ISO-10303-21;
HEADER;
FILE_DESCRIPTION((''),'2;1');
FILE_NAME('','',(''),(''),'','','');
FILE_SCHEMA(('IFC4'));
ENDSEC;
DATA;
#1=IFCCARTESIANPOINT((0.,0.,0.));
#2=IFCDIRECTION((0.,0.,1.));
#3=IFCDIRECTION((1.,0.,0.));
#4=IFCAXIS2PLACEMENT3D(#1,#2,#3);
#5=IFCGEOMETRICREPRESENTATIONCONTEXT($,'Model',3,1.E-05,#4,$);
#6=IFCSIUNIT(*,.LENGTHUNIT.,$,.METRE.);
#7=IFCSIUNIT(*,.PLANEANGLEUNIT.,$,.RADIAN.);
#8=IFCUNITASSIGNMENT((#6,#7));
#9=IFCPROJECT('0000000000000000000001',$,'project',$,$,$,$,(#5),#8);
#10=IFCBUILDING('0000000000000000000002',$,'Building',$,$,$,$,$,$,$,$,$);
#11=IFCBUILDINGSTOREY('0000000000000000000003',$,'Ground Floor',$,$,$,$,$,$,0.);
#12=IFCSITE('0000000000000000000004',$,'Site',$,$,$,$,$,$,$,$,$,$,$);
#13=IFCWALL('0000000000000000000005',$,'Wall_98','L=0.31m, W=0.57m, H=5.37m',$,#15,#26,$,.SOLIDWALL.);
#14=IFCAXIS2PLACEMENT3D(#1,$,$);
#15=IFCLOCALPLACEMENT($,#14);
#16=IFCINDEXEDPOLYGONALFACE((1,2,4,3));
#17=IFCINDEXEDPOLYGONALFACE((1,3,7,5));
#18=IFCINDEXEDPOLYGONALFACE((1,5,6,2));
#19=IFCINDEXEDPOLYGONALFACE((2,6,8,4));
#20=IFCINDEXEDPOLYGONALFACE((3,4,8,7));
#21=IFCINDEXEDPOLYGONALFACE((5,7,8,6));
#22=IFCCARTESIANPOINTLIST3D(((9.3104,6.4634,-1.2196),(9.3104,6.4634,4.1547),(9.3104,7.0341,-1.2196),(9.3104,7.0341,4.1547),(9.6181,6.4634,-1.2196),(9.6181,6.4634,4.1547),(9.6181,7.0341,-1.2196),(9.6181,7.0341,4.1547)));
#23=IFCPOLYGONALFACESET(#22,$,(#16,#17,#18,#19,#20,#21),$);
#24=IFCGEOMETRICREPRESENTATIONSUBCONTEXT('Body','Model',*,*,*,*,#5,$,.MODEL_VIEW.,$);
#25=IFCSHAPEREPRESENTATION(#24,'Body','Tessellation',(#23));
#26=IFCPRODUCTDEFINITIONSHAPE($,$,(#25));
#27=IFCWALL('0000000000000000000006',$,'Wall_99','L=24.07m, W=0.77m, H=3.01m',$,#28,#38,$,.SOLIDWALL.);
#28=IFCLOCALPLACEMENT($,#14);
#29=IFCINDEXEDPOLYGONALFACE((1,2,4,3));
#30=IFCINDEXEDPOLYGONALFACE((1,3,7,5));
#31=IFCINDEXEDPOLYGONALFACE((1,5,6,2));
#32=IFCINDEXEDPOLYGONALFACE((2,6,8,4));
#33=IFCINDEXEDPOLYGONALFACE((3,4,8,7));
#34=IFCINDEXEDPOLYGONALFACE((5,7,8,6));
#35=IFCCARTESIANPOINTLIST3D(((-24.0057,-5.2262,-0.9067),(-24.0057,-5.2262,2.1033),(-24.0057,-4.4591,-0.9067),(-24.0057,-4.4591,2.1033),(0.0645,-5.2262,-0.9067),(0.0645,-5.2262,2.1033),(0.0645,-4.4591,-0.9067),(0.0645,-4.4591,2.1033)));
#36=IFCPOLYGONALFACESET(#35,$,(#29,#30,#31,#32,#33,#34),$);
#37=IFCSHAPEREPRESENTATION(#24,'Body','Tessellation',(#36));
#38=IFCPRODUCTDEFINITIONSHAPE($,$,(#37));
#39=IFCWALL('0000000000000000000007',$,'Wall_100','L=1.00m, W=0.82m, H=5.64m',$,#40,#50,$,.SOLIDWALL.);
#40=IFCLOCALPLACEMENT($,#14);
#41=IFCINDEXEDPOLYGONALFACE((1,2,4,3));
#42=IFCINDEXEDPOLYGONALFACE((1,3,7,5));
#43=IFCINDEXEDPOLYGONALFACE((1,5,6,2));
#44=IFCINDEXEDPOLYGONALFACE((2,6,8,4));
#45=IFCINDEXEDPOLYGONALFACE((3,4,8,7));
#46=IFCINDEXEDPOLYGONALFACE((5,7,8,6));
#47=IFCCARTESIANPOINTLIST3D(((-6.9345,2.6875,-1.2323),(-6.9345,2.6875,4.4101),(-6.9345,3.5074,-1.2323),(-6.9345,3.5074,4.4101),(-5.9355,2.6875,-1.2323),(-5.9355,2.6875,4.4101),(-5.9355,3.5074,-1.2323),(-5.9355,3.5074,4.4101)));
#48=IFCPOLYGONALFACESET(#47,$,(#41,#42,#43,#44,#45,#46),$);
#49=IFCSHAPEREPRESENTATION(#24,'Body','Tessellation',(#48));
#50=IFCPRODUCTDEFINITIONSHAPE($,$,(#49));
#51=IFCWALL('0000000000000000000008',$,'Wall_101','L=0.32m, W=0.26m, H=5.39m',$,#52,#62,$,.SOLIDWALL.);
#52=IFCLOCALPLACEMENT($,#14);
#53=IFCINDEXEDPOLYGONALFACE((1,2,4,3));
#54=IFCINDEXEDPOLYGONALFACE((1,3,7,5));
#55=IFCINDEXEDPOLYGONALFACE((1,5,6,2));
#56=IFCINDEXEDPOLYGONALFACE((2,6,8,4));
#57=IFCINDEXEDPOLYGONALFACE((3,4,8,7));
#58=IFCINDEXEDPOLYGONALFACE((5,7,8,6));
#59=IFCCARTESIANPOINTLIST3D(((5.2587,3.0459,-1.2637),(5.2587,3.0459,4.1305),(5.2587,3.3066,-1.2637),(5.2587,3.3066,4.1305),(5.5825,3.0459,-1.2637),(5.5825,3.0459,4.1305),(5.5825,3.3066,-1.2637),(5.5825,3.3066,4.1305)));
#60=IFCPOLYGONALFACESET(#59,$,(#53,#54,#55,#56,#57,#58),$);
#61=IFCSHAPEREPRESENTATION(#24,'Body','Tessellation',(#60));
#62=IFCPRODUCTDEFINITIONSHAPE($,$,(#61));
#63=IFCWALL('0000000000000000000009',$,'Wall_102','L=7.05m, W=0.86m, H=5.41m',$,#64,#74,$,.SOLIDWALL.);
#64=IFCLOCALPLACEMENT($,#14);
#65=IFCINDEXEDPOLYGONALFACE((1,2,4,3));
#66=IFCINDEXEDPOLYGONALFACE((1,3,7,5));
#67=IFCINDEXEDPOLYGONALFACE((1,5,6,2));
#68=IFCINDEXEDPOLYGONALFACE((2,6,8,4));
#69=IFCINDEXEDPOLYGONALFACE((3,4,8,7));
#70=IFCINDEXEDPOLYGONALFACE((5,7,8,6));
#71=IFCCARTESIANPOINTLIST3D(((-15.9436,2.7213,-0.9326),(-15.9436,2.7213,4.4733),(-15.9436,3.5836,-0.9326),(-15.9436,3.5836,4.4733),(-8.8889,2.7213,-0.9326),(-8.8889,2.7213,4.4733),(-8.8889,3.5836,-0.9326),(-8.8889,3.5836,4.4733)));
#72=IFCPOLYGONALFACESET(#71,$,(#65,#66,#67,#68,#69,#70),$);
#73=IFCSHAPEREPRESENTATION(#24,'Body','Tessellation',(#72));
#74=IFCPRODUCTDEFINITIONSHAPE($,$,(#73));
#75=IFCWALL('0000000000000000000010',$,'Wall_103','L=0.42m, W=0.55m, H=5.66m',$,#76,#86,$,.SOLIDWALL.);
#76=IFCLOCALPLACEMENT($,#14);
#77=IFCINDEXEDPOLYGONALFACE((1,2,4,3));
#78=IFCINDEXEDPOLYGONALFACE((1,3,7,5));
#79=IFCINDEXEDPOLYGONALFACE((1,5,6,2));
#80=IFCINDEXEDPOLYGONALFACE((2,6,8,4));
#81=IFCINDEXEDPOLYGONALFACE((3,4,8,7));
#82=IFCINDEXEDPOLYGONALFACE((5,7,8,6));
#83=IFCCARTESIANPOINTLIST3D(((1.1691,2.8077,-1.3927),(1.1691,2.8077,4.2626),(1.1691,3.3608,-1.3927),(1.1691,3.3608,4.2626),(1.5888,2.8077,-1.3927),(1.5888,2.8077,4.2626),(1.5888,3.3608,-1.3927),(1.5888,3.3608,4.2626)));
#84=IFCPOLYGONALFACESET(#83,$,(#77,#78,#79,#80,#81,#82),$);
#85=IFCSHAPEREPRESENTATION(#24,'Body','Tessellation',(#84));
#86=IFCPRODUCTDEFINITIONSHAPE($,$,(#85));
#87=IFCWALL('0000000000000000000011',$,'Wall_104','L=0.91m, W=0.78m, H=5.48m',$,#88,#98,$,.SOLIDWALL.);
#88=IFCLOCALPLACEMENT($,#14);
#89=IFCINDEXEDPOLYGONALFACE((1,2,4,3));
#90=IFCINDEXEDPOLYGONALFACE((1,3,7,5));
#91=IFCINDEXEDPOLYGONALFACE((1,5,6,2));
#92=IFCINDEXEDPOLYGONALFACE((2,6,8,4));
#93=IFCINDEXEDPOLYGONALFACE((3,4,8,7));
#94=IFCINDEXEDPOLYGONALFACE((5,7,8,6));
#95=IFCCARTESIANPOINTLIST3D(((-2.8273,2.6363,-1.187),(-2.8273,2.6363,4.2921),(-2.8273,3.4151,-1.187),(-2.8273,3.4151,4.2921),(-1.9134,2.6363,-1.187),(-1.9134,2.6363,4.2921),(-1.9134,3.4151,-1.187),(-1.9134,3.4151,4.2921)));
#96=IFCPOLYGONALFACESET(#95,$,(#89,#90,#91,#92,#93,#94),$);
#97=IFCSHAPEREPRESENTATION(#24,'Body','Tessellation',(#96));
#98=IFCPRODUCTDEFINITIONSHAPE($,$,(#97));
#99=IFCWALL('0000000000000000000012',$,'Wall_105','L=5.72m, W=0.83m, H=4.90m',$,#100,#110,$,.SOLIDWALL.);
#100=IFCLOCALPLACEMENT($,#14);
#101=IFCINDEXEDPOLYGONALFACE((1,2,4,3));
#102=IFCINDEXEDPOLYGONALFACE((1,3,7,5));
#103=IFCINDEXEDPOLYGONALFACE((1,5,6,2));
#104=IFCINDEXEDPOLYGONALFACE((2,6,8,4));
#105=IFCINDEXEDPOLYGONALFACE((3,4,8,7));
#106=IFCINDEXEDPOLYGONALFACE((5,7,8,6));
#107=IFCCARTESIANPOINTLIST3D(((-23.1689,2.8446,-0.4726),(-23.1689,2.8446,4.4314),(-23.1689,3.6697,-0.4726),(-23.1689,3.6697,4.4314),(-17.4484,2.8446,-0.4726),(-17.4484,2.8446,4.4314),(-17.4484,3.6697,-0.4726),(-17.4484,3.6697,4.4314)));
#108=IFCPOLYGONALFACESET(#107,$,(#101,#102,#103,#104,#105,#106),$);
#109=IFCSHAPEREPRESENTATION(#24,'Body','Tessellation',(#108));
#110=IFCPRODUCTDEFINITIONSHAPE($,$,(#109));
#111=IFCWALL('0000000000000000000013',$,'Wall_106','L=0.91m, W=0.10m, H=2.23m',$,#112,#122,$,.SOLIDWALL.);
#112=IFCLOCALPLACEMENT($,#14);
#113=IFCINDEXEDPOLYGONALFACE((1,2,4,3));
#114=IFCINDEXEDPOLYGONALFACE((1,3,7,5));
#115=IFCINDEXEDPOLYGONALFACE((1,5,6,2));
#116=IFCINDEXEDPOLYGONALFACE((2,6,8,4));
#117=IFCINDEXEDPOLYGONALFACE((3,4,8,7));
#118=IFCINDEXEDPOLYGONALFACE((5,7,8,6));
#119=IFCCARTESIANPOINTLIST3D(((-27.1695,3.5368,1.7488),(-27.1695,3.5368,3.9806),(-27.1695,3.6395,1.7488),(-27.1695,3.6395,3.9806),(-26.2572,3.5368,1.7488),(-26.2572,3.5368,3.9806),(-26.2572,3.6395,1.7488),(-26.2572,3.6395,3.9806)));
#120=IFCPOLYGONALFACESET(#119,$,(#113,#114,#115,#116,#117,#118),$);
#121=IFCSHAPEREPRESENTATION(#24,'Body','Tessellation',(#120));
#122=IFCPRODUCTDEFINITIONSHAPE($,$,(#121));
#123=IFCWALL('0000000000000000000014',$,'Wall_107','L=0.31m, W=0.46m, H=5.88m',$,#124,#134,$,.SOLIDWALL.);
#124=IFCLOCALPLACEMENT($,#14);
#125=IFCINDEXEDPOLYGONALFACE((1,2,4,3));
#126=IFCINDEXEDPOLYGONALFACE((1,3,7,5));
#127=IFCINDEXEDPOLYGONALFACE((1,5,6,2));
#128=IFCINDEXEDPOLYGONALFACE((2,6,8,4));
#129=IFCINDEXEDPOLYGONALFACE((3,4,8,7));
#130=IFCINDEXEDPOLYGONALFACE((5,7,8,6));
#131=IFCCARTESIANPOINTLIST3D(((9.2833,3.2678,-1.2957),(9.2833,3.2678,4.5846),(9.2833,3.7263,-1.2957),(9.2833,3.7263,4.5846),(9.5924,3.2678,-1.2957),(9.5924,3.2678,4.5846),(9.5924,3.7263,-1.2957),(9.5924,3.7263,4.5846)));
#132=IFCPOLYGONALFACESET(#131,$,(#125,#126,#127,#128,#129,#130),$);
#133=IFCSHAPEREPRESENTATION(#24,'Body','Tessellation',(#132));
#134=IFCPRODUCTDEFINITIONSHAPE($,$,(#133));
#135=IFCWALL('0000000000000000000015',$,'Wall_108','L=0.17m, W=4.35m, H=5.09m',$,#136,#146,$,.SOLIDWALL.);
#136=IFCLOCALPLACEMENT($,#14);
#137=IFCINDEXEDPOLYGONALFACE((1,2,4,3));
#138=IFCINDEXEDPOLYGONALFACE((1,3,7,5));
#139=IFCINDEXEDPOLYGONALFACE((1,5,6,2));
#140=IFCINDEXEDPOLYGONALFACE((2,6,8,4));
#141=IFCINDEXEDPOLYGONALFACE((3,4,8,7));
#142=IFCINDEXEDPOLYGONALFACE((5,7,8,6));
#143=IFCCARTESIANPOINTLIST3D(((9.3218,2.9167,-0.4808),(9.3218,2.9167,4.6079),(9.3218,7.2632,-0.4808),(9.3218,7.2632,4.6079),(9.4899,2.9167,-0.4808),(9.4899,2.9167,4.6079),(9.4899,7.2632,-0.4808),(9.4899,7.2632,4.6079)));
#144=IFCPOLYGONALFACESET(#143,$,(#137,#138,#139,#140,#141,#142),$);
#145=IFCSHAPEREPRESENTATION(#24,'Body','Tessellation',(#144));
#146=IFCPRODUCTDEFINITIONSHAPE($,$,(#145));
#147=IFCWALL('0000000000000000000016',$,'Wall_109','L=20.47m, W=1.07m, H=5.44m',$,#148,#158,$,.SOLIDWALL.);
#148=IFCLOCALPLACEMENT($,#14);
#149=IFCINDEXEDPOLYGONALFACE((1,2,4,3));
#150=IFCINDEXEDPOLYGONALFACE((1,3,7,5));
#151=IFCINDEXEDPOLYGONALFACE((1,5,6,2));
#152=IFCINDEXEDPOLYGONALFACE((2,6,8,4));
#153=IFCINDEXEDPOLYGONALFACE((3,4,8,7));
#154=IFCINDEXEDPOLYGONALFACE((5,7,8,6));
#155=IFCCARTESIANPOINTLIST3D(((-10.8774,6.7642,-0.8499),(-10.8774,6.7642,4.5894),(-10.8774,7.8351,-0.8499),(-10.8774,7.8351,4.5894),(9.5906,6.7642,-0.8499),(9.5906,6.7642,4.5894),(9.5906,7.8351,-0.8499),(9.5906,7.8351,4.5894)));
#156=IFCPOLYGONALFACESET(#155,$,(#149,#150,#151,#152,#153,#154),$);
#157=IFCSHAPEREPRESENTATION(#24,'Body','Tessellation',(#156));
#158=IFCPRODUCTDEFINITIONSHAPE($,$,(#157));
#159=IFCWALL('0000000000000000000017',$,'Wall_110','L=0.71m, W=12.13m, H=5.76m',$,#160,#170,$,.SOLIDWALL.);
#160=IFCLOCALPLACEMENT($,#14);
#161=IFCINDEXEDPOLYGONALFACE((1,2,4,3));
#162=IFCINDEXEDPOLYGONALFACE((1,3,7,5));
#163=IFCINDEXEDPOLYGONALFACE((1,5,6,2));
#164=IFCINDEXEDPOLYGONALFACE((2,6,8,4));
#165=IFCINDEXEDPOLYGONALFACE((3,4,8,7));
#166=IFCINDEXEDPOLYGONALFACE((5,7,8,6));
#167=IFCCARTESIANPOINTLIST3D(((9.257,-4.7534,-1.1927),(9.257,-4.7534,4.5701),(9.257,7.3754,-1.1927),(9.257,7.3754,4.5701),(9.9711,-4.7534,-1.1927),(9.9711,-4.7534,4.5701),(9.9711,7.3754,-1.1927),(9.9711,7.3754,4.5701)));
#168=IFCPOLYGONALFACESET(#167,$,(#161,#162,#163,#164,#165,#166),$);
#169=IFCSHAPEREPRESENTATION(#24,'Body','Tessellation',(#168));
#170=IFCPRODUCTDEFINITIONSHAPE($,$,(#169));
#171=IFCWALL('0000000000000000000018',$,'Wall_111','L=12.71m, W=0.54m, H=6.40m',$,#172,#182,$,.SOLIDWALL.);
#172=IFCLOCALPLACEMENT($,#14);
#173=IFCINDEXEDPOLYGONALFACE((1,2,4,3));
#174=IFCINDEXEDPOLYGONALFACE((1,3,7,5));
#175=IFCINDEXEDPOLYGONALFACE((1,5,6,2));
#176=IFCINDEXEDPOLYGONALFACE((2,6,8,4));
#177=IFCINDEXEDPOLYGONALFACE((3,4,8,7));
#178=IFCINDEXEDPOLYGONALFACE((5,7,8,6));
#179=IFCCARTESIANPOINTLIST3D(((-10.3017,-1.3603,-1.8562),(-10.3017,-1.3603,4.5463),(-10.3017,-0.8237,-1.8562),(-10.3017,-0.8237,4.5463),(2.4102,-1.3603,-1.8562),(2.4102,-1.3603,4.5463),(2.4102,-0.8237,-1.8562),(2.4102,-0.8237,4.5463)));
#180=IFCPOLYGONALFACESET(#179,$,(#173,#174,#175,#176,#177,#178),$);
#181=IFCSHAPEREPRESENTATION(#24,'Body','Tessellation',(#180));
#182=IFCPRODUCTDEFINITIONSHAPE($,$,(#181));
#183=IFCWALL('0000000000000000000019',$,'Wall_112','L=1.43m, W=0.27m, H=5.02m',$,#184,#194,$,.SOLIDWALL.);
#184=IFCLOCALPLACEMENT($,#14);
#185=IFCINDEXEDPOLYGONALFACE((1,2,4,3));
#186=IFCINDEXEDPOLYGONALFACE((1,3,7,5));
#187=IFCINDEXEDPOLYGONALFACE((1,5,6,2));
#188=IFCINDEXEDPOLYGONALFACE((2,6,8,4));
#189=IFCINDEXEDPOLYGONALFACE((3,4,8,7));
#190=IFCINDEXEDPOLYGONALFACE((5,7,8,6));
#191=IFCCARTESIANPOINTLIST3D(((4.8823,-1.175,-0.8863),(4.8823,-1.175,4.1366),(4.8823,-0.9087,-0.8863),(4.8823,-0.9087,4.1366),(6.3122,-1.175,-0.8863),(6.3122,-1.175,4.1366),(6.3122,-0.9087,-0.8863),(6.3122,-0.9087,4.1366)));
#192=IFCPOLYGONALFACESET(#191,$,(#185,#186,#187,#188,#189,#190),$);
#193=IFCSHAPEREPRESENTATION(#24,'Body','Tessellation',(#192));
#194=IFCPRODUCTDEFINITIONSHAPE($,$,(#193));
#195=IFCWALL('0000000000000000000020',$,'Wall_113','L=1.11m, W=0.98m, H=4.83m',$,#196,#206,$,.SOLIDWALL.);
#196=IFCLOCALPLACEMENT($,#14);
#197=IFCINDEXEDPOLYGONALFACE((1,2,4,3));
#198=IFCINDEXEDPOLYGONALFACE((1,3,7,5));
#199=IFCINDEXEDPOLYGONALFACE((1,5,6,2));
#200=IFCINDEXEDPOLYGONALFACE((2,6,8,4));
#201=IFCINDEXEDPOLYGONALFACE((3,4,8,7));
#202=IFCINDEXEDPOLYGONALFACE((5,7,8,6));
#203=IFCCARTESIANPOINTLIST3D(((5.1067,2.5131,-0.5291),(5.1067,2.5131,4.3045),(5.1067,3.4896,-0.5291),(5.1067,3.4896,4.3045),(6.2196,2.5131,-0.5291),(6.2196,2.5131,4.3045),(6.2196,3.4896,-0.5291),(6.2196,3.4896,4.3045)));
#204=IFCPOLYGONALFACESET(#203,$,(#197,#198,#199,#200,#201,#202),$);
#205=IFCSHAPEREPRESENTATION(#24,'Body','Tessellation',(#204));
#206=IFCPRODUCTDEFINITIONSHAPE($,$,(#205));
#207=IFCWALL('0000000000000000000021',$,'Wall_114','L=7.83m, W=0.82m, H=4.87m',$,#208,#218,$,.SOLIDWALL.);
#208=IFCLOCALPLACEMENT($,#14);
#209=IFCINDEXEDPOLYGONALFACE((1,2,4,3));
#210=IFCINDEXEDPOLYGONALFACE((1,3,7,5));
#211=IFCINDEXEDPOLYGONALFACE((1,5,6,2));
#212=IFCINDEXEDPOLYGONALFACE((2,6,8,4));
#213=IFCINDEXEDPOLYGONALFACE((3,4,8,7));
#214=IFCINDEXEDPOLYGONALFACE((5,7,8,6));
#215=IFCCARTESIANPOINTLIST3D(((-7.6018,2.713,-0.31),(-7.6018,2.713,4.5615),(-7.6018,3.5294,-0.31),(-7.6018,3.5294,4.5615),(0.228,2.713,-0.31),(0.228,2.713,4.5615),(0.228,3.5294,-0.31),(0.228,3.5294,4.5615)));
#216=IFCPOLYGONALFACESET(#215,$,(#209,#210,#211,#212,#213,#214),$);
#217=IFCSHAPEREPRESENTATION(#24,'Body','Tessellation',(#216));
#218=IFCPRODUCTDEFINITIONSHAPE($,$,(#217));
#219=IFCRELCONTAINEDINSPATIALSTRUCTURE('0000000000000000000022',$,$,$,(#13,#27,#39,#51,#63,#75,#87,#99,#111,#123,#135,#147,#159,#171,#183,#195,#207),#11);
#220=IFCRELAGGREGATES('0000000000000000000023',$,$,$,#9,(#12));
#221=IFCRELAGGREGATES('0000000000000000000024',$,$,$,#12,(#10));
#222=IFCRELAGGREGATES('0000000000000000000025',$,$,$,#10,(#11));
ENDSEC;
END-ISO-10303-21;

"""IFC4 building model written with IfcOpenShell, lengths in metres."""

from ifc_helpers import new_model, si_unit, frame, origin_with_axes, origin_2d, context, subcontext, project, spatial, rectangle, extrude, element, save


model = new_model("IFC4")

# Units and contexts
model_context = context("Model", 3, precision=1e-05, world=origin_with_axes())
body_context = subcontext(model_context, "Body", "Model", "MODEL_VIEW")
ifc_project = project(units=[si_unit("LENGTHUNIT", "METRE"), si_unit("PLANEANGLEUNIT", "RADIAN")], contexts=[model_context])

# Site, building, storey
site = spatial("IfcSite", under=ifc_project, Name="Site")
building = spatial("IfcBuilding", under=site, Name="Building")
storey = spatial("IfcBuildingStorey", under=building, Name="Ground Floor", Elevation=0.0)

# Walls
element("IfcWall", 1, inside=storey, Name="Wall_98", Description="L=0.31m, W=0.57m, H=5.37m", PredefinedType="SOLIDWALL", context=body_context, shape_type="SweptSolid", body=[
    extrude(rectangle(XDim=0.3077, YDim=0.5707, at=origin_2d()), frame((9.4642, 6.7487, -1.2196), z_axis=(0.0, 0.0, 1.0), x_axis=(1.0, 0.0, 0.0)), (0.0, 0.0, 1.0), 5.3743),
])
element("IfcWall", 2, inside=storey, Name="Wall_99", Description="L=24.07m, W=0.77m, H=3.01m", PredefinedType="SOLIDWALL", context=body_context, shape_type="SweptSolid", body=[
    extrude(rectangle(XDim=24.0702, YDim=0.7671, at=origin_2d()), frame((-11.9706, -4.8426, -0.9067), z_axis=(0.0, 0.0, 1.0), x_axis=(1.0, 0.0, 0.0)), (0.0, 0.0, 1.0), 3.01),
])
element("IfcWall", 3, inside=storey, Name="Wall_100", Description="L=1.00m, W=0.82m, H=5.64m", PredefinedType="SOLIDWALL", context=body_context, shape_type="SweptSolid", body=[
    extrude(rectangle(XDim=0.999, YDim=0.8198, at=origin_2d()), frame((-6.435, 3.0974, -1.2323), z_axis=(0.0, 0.0, 1.0), x_axis=(1.0, 0.0, 0.0)), (0.0, 0.0, 1.0), 5.6424),
])
element("IfcWall", 4, inside=storey, Name="Wall_101", Description="L=0.32m, W=0.26m, H=5.39m", PredefinedType="SOLIDWALL", context=body_context, shape_type="SweptSolid", body=[
    extrude(rectangle(XDim=0.3237, YDim=0.2606, at=origin_2d()), frame((5.4206, 3.1763, -1.2637), z_axis=(0.0, 0.0, 1.0), x_axis=(1.0, 0.0, 0.0)), (0.0, 0.0, 1.0), 5.3941),
])
element("IfcWall", 5, inside=storey, Name="Wall_102", Description="L=7.05m, W=0.86m, H=5.41m", PredefinedType="SOLIDWALL", context=body_context, shape_type="SweptSolid", body=[
    extrude(rectangle(XDim=7.0547, YDim=0.8623, at=origin_2d()), frame((-12.4163, 3.1524, -0.9326), z_axis=(0.0, 0.0, 1.0), x_axis=(1.0, 0.0, 0.0)), (0.0, 0.0, 1.0), 5.4059),
])
element("IfcWall", 6, inside=storey, Name="Wall_103", Description="L=0.42m, W=0.55m, H=5.66m", PredefinedType="SOLIDWALL", context=body_context, shape_type="SweptSolid", body=[
    extrude(rectangle(XDim=0.4197, YDim=0.5531, at=origin_2d()), frame((1.379, 3.0842, -1.3927), z_axis=(0.0, 0.0, 1.0), x_axis=(1.0, 0.0, 0.0)), (0.0, 0.0, 1.0), 5.6553),
])
element("IfcWall", 7, inside=storey, Name="Wall_104", Description="L=0.91m, W=0.78m, H=5.48m", PredefinedType="SOLIDWALL", context=body_context, shape_type="SweptSolid", body=[
    extrude(rectangle(XDim=0.9138, YDim=0.7788, at=origin_2d()), frame((-2.3703, 3.0257, -1.187), z_axis=(0.0, 0.0, 1.0), x_axis=(1.0, 0.0, 0.0)), (0.0, 0.0, 1.0), 5.4791),
])
element("IfcWall", 8, inside=storey, Name="Wall_105", Description="L=5.72m, W=0.83m, H=4.90m", PredefinedType="SOLIDWALL", context=body_context, shape_type="SweptSolid", body=[
    extrude(rectangle(XDim=5.7205, YDim=0.8251, at=origin_2d()), frame((-20.3086, 3.2571, -0.4726), z_axis=(0.0, 0.0, 1.0), x_axis=(1.0, 0.0, 0.0)), (0.0, 0.0, 1.0), 4.9039),
])
element("IfcWall", 9, inside=storey, Name="Wall_106", Description="L=0.91m, W=0.10m, H=2.23m", PredefinedType="SOLIDWALL", context=body_context, shape_type="SweptSolid", body=[
    extrude(rectangle(XDim=0.9124, YDim=0.1028, at=origin_2d()), frame((-26.7134, 3.5881, 1.7488), z_axis=(0.0, 0.0, 1.0), x_axis=(1.0, 0.0, 0.0)), (0.0, 0.0, 1.0), 2.2317),
])
element("IfcWall", 10, inside=storey, Name="Wall_107", Description="L=0.31m, W=0.46m, H=5.88m", PredefinedType="SOLIDWALL", context=body_context, shape_type="SweptSolid", body=[
    extrude(rectangle(XDim=0.3092, YDim=0.4585, at=origin_2d()), frame((9.4379, 3.497, -1.2957), z_axis=(0.0, 0.0, 1.0), x_axis=(1.0, 0.0, 0.0)), (0.0, 0.0, 1.0), 5.8803),
])
element("IfcWall", 11, inside=storey, Name="Wall_108", Description="L=0.17m, W=4.35m, H=5.09m", PredefinedType="SOLIDWALL", context=body_context, shape_type="SweptSolid", body=[
    extrude(rectangle(XDim=0.1681, YDim=4.3465, at=origin_2d()), frame((9.4059, 5.09, -0.4808), z_axis=(0.0, 0.0, 1.0), x_axis=(1.0, 0.0, 0.0)), (0.0, 0.0, 1.0), 5.0886),
])
element("IfcWall", 12, inside=storey, Name="Wall_109", Description="L=20.47m, W=1.07m, H=5.44m", PredefinedType="SOLIDWALL", context=body_context, shape_type="SweptSolid", body=[
    extrude(rectangle(XDim=20.468, YDim=1.0709, at=origin_2d()), frame((-0.6434, 7.2996, -0.8499), z_axis=(0.0, 0.0, 1.0), x_axis=(1.0, 0.0, 0.0)), (0.0, 0.0, 1.0), 5.4393),
])
element("IfcWall", 13, inside=storey, Name="Wall_110", Description="L=0.71m, W=12.13m, H=5.76m", PredefinedType="SOLIDWALL", context=body_context, shape_type="SweptSolid", body=[
    extrude(rectangle(XDim=0.7141, YDim=12.1288, at=origin_2d()), frame((9.614, 1.311, -1.1927), z_axis=(0.0, 0.0, 1.0), x_axis=(1.0, 0.0, 0.0)), (0.0, 0.0, 1.0), 5.7628),
])
element("IfcWall", 14, inside=storey, Name="Wall_111", Description="L=12.71m, W=0.54m, H=6.40m", PredefinedType="SOLIDWALL", context=body_context, shape_type="SweptSolid", body=[
    extrude(rectangle(XDim=12.7119, YDim=0.5366, at=origin_2d()), frame((-3.9457, -1.092, -1.8562), z_axis=(0.0, 0.0, 1.0), x_axis=(1.0, 0.0, 0.0)), (0.0, 0.0, 1.0), 6.4025),
])
element("IfcWall", 15, inside=storey, Name="Wall_112", Description="L=1.43m, W=0.27m, H=5.02m", PredefinedType="SOLIDWALL", context=body_context, shape_type="SweptSolid", body=[
    extrude(rectangle(XDim=1.43, YDim=0.2663, at=origin_2d()), frame((5.5972, -1.0419, -0.8863), z_axis=(0.0, 0.0, 1.0), x_axis=(1.0, 0.0, 0.0)), (0.0, 0.0, 1.0), 5.0229),
])
element("IfcWall", 16, inside=storey, Name="Wall_113", Description="L=1.11m, W=0.98m, H=4.83m", PredefinedType="SOLIDWALL", context=body_context, shape_type="SweptSolid", body=[
    extrude(rectangle(XDim=1.1129, YDim=0.9766, at=origin_2d()), frame((5.6631, 3.0014, -0.5291), z_axis=(0.0, 0.0, 1.0), x_axis=(1.0, 0.0, 0.0)), (0.0, 0.0, 1.0), 4.8336),
])
element("IfcWall", 17, inside=storey, Name="Wall_114", Description="L=7.83m, W=0.82m, H=4.87m", PredefinedType="SOLIDWALL", context=body_context, shape_type="SweptSolid", body=[
    extrude(rectangle(XDim=7.8298, YDim=0.8164, at=origin_2d()), frame((-3.6869, 3.1212, -0.31), z_axis=(0.0, 0.0, 1.0), x_axis=(1.0, 0.0, 0.0)), (0.0, 0.0, 1.0), 4.8715),
])

save(model, "model.ifc")
